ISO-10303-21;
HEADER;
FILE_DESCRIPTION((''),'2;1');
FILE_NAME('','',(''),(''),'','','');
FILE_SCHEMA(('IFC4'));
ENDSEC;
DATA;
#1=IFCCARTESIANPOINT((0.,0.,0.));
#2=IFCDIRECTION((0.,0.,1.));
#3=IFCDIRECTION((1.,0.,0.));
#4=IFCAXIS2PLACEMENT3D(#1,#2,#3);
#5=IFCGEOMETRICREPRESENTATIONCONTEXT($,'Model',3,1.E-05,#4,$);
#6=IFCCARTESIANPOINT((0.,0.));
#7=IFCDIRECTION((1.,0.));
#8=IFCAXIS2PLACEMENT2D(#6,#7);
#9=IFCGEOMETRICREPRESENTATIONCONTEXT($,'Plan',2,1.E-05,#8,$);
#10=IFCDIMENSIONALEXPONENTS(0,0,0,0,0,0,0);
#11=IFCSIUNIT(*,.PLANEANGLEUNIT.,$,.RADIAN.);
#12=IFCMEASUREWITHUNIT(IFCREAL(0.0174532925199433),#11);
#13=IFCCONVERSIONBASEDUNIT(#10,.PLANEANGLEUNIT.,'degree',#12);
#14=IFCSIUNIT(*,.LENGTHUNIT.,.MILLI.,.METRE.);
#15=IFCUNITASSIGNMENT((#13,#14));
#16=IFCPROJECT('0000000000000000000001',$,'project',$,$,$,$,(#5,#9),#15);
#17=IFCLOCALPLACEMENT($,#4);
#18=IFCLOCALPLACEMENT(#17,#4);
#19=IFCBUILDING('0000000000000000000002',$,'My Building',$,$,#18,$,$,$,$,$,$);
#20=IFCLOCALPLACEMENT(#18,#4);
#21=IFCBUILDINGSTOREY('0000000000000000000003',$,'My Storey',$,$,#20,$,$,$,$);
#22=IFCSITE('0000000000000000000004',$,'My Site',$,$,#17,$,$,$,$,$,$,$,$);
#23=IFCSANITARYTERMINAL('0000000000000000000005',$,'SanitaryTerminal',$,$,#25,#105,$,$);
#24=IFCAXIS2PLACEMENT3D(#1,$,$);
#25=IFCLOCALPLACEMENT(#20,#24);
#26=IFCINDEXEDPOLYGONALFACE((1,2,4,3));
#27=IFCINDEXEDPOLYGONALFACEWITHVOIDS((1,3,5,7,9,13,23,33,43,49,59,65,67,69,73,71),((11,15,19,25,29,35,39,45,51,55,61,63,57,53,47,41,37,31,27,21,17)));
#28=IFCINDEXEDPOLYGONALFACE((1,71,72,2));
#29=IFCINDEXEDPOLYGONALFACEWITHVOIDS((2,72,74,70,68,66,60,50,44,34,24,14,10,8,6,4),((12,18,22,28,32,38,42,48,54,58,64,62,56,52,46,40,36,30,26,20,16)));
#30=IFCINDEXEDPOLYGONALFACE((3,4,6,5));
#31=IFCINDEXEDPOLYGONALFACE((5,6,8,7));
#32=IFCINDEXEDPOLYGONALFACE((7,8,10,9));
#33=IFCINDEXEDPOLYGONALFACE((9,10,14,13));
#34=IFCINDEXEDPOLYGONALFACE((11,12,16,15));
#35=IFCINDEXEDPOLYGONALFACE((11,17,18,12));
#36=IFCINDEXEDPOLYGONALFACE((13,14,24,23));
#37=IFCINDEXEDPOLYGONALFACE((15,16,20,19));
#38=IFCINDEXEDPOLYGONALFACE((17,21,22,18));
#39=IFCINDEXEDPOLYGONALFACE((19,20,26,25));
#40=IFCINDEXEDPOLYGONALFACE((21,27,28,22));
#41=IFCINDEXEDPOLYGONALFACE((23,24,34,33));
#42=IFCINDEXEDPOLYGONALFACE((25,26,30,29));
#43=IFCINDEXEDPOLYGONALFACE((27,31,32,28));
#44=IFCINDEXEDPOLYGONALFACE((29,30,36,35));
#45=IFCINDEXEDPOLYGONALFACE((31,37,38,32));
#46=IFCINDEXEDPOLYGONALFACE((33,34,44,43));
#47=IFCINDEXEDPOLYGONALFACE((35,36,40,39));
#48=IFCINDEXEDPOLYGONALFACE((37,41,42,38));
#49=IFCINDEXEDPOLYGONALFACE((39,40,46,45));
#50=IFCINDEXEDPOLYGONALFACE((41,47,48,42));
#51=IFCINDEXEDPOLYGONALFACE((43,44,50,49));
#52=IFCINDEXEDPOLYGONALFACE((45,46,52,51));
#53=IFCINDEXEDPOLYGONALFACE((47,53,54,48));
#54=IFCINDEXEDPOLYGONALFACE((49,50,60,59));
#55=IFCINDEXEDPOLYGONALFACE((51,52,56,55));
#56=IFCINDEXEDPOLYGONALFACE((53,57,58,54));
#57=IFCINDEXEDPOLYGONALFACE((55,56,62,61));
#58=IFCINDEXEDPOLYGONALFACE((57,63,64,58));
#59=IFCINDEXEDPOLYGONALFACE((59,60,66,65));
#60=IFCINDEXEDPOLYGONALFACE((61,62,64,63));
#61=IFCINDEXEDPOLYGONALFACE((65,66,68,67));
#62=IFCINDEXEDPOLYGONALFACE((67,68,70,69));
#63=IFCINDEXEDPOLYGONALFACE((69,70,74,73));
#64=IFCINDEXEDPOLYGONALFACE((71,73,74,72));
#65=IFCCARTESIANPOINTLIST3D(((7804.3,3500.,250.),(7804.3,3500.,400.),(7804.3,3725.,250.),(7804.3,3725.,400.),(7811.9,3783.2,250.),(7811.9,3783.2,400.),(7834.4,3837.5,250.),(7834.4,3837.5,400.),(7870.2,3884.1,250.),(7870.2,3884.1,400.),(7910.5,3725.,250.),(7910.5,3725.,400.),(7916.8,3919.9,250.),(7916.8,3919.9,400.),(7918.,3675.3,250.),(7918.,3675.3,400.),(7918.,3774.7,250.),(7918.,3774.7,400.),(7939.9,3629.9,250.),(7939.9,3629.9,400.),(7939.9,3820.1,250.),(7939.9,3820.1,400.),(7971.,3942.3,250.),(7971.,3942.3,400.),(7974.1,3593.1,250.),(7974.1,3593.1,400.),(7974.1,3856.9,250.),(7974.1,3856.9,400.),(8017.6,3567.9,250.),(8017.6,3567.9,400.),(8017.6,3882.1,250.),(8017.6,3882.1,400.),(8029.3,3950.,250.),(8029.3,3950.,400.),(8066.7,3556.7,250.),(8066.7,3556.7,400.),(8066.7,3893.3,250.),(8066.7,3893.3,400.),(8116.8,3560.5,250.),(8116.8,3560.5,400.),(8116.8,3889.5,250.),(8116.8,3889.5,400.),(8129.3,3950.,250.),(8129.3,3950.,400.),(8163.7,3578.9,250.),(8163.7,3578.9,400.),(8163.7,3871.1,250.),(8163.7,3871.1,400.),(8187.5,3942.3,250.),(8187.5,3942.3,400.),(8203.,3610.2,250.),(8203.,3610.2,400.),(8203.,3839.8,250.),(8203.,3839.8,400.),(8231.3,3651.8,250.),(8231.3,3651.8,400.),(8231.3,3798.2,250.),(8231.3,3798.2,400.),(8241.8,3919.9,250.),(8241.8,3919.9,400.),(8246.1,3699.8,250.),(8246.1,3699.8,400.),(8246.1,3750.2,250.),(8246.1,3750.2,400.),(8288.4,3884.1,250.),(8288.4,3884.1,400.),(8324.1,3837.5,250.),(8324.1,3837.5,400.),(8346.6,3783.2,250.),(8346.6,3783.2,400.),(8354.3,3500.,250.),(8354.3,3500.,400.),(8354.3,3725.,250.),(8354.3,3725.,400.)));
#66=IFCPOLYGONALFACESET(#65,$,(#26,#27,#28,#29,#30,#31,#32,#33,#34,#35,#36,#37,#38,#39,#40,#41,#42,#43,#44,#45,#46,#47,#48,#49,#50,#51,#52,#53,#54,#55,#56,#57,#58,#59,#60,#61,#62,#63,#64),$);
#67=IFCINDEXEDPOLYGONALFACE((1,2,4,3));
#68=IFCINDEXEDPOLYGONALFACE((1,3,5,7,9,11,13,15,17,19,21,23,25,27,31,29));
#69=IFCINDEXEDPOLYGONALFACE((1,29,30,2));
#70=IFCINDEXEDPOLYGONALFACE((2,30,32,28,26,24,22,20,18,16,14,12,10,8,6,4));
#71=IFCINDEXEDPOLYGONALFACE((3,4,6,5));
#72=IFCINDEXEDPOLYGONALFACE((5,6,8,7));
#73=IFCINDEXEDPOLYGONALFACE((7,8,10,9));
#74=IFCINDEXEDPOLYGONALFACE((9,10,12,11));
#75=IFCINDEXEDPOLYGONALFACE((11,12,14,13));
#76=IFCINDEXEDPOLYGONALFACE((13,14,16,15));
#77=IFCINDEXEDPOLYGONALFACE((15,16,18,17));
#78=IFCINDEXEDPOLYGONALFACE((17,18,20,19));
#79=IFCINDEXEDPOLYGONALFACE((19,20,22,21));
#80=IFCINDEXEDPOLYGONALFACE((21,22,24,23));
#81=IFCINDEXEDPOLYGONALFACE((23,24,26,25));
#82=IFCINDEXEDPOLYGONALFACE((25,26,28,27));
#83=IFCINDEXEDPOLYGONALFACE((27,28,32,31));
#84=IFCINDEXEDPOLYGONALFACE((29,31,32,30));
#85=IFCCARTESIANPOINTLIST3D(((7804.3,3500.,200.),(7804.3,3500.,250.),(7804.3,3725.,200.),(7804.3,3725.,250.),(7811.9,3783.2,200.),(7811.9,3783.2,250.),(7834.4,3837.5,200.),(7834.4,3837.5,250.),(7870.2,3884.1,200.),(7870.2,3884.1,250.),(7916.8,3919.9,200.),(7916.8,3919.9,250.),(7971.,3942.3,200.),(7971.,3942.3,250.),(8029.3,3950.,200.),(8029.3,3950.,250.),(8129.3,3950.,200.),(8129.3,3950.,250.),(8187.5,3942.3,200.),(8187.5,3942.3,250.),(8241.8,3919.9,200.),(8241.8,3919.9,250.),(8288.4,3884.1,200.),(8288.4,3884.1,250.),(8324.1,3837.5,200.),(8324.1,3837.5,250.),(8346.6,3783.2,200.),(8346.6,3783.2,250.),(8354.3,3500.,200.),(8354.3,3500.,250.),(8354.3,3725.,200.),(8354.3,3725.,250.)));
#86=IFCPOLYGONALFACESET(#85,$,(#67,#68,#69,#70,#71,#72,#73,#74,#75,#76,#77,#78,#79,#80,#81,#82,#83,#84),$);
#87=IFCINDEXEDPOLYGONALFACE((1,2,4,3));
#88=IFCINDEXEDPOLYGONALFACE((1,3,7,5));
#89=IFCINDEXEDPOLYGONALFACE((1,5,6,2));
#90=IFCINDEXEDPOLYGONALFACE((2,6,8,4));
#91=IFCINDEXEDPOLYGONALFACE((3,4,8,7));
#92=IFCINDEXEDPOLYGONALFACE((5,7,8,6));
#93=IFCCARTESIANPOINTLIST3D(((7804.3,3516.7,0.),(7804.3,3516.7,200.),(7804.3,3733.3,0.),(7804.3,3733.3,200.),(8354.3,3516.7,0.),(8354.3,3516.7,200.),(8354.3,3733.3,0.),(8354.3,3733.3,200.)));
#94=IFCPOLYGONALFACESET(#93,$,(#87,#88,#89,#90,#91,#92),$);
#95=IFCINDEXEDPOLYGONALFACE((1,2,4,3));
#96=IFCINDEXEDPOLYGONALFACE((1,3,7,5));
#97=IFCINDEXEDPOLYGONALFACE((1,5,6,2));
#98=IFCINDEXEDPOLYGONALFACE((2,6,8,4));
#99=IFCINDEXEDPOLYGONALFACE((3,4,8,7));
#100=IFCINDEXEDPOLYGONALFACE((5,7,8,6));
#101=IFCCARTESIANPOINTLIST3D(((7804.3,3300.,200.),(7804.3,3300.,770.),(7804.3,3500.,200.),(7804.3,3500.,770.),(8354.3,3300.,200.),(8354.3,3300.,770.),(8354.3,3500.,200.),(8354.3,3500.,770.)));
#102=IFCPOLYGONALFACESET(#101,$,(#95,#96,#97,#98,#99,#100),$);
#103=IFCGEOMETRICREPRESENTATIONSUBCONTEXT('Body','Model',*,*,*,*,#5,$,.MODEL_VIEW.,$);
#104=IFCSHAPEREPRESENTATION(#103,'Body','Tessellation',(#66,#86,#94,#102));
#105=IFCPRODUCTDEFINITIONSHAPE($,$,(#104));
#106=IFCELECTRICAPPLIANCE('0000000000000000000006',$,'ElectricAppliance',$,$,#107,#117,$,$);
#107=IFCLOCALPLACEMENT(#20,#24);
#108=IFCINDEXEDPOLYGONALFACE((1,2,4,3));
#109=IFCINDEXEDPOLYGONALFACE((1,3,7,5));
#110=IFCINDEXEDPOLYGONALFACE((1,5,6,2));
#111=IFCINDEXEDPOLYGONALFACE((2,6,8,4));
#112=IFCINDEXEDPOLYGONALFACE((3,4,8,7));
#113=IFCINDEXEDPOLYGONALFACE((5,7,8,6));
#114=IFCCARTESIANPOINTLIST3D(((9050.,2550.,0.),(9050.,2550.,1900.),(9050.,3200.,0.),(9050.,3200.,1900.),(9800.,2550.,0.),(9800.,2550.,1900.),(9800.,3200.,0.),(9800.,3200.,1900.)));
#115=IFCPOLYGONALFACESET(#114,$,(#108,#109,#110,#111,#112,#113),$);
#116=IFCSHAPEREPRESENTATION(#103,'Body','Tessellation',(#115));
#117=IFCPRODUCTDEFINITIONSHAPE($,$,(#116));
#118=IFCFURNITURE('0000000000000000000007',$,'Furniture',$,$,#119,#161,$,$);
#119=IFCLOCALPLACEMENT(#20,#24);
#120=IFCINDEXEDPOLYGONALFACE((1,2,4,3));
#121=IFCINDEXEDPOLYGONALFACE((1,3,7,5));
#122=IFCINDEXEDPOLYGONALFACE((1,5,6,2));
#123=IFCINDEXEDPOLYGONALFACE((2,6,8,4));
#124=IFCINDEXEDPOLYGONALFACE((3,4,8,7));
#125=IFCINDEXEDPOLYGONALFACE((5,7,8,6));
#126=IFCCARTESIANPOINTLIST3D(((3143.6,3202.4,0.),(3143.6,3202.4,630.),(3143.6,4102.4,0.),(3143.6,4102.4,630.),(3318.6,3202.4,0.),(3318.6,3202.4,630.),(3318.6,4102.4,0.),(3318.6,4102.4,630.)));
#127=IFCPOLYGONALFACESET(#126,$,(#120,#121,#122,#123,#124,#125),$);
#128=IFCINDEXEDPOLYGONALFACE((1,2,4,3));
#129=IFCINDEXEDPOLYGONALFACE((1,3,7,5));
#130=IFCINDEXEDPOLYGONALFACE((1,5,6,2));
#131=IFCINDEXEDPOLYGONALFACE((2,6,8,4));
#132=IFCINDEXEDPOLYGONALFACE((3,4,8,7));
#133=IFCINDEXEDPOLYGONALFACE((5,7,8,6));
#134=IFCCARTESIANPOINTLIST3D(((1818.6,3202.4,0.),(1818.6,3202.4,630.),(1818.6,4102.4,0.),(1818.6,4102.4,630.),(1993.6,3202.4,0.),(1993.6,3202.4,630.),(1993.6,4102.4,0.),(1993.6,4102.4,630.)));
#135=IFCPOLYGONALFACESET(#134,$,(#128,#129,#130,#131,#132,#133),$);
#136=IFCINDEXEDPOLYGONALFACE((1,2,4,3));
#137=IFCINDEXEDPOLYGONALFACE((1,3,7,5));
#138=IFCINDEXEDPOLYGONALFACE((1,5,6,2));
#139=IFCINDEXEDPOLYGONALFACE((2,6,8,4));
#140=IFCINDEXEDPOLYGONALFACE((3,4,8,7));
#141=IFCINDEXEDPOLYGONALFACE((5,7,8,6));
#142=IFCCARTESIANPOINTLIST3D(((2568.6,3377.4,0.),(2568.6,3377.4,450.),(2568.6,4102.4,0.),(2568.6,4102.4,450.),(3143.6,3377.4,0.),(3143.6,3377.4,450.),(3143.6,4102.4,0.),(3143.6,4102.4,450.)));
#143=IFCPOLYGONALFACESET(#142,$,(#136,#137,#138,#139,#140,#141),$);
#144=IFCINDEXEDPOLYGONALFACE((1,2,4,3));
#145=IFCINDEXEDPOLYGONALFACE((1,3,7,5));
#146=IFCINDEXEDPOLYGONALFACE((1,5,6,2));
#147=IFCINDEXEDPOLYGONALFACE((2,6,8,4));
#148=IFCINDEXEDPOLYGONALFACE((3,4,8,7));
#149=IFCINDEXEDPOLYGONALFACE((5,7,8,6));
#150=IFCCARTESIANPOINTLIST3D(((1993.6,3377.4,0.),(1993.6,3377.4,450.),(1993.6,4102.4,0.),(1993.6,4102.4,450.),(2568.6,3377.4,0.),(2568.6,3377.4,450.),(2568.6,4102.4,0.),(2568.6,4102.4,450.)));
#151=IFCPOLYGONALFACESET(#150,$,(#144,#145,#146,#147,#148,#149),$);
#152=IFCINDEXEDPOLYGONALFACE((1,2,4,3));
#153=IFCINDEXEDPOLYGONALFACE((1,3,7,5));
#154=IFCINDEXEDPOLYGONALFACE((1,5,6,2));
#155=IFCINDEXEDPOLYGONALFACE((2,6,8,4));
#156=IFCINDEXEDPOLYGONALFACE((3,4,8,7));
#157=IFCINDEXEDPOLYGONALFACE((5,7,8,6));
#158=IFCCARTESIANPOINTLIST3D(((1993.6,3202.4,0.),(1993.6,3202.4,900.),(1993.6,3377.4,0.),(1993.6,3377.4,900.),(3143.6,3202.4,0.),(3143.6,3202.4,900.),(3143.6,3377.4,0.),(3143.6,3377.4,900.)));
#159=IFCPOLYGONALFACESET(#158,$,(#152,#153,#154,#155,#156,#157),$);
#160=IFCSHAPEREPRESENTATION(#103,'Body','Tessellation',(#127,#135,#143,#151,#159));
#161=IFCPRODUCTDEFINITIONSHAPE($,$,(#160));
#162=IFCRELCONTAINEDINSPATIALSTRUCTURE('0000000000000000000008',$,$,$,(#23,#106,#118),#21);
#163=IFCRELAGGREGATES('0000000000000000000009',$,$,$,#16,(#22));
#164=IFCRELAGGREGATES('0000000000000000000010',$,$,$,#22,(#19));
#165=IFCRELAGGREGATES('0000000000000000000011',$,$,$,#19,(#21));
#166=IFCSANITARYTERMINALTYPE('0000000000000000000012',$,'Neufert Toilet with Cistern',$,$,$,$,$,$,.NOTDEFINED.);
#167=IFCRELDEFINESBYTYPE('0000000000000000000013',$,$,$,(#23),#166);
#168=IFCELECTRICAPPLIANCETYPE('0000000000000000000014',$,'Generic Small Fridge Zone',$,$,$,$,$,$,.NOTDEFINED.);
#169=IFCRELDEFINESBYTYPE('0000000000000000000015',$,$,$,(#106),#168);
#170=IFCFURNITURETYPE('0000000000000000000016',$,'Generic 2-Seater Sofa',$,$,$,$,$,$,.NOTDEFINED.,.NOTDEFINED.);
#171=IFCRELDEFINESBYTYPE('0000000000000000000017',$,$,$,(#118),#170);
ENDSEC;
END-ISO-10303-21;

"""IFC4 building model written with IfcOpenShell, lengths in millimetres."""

from ifc_helpers import new_model, entity, si_unit, converted_unit, frame, frame_2d, origin_with_axes, origin_2d_with_axis, place, context, subcontext, project, spatial, line, arc, indexed_curve, circle_curve, outline, extrude, shape, source, transform, mapped, type_object, type_shapes, element, save


model = new_model("IFC4")

# Units and contexts
model_context = context("Model", 3, precision=1e-05, world=origin_with_axes())
plan_context = context("Plan", 2, precision=1e-05, world=origin_2d_with_axis())
body_context_1 = subcontext(model_context, "Body", "Model", "MODEL_VIEW")
body_context_2 = subcontext(plan_context, "Body", "Plan", "PLAN_VIEW")
ifc_project = project(units=[converted_unit("PLANEANGLEUNIT", "degree", entity("IfcReal", 0.0174532925199433), si_unit("PLANEANGLEUNIT", "RADIAN"), dimensions=[0, 0, 0, 0, 0, 0, 0]), si_unit("LENGTHUNIT", "METRE", prefix="MILLI")], contexts=[model_context, plan_context])

# Site, building, storey
site_placement = place(None, origin_with_axes())
site = spatial("IfcSite", under=ifc_project, at=site_placement, Name="My Site")
building_placement = place(site_placement, origin_with_axes())
building = spatial("IfcBuilding", under=site, at=building_placement, Name="My Building")
storey_placement = place(building_placement, origin_with_axes())
storey = spatial("IfcBuildingStorey", under=building, at=storey_placement, Name="My Storey")

# Sanitary terminal
sanitary_terminal_type_1 = type_object("IfcSanitaryTerminalType", Name="Neufert Toilet with Cistern", PredefinedType="NOTDEFINED")
shared_shape_1 = source(origin_with_axes(), body_context_1, "Body", "SweptSolid", [
    extrude(outline(indexed_curve([(-275.0, -200.0), (275.0, -200.0), (275.0, -425.0), (209.1, -584.1), (50.0, -650.0), (-50.0, -650.0), (-209.1, -584.1), (-275.0, -425.0)], segments=[line(1, 2), line(2, 3), arc(3, 4, 5), line(5, 6), arc(6, 7, 8), line(8, 1)]), holes=[circle_curve(frame_2d((0.0, -425.0)), 168.8)]), frame((0.0, 0.0, 250.0), z_axis=(0.0, 0.0, 1.0), x_axis=(1.0, 0.0, 0.0)), (0.0, 0.0, 1.0), 150.0),
    extrude(outline(indexed_curve([(-275.0, -200.0), (275.0, -200.0), (275.0, -425.0), (209.1, -584.1), (50.0, -650.0), (-50.0, -650.0), (-209.1, -584.1), (-275.0, -425.0)], segments=[line(1, 2), line(2, 3), arc(3, 4, 5), line(5, 6), arc(6, 7, 8), line(8, 1)])), frame((0.0, 0.0, 200.0), z_axis=(0.0, 0.0, 1.0), x_axis=(1.0, 0.0, 0.0)), (0.0, 0.0, 1.0), 50.0),
    extrude(outline(indexed_curve([(-275.0, -216.7), (275.0, -216.7), (275.0, -433.3), (-275.0, -433.3)], segments=[line(1, 2, 3, 4, 1)])), origin_with_axes(), (0.0, 0.0, 1.0), 200.0),
    extrude(outline(indexed_curve([(-275.0, 0.0), (275.0, 0.0), (275.0, -200.0), (-275.0, -200.0)], segments=[line(1, 2, 3, 4, 1)])), frame((0.0, 0.0, 200.0), z_axis=(0.0, 0.0, 1.0), x_axis=(1.0, 0.0, 0.0)), (0.0, 0.0, 1.0), 570.0),
])
shared_shape_2 = source(origin_with_axes(), body_context_2, "Body", "Curve2D", [
    entity("IfcIndexedPolyCurve", entity("IfcCartesianPointList2D", [[-275.0, 0.0], [275.0, 0.0], [275.0, -200.0], [-275.0, -200.0]]), [entity("IfcLineIndex", [1, 2, 3, 4, 1])]),
    entity("IfcIndexedPolyCurve", entity("IfcCartesianPointList2D", [[165.0, -200.0], [192.5, -335.0]])),
    entity("IfcTrimmedCurve", entity("IfcEllipse", entity("IfcAxis2Placement2D", entity("IfcCartesianPoint", [0.0, -335.0]), entity("IfcDirection", [1.0, 0.0])), 192.5, 315.0), [entity("IfcCartesianPoint", [-192.5, -335.0])], [entity("IfcCartesianPoint", [192.5, -335.0])], True, "CARTESIAN"),
    entity("IfcIndexedPolyCurve", entity("IfcCartesianPointList2D", [[-165.0, -200.0], [-192.5, -335.0]])),
    entity("IfcEllipse", entity("IfcAxis2Placement2D", entity("IfcCartesianPoint", [0.0, -452.0]), entity("IfcDirection", [1.0, 0.0])), 131.2, 157.5),
    entity("IfcIndexedPolyCurve", entity("IfcCartesianPointList2D", [[-34.4, -452.0], [-34.4, -429.5], [34.4, -429.5], [34.4, -452.0]])),
    entity("IfcTrimmedCurve", entity("IfcEllipse", entity("IfcAxis2Placement2D", entity("IfcCartesianPoint", [0.0, -452.0]), entity("IfcDirection", [1.0, 0.0])), 34.4, 22.5), [entity("IfcCartesianPoint", [-34.4, -452.0])], [entity("IfcCartesianPoint", [34.4, -452.0])], True, "CARTESIAN"),
])
type_shapes(sanitary_terminal_type_1, [shared_shape_1, shared_shape_2])
sanitary_terminal_1_placement = place(storey_placement, frame((8079.3, 3300.0, 0.0), z_axis=(0.0, 0.0, 1.0), x_axis=(-1.0, 0.0, 0.0)))
element("IfcSanitaryTerminal", 1, at=sanitary_terminal_1_placement, inside=storey, type_object=sanitary_terminal_type_1, Name="SanitaryTerminal", shapes=[
    shape(body_context_1, "Body", "MappedRepresentation", [mapped(shared_shape_1, transform((0.0, 0.0, 0.0), x_axis=(1.0, 0.0, 0.0), y_axis=(0.0, 1.0, 0.0), z_axis=(0.0, 0.0, 1.0), scale=1.0))]),
    shape(body_context_2, "Body", "MappedRepresentation", [mapped(shared_shape_2, transform((0.0, 0.0, 0.0), x_axis=(1.0, 0.0, 0.0), y_axis=(0.0, 1.0, 0.0), z_axis=(0.0, 0.0, 1.0), scale=1.0))]),
])

# Electric appliance
electric_appliance_type_1 = type_object("IfcElectricApplianceType", Name="Generic Small Fridge Zone", PredefinedType="NOTDEFINED")
shared_shape_3 = source(origin_with_axes(), body_context_1, "Body", "SweptSolid", [
    extrude(outline(indexed_curve([(0.0, 0.0), (750.0, 0.0), (750.0, 650.0), (0.0, 650.0)], segments=[line(1, 2, 3, 4, 1)])), origin_with_axes(), (0.0, 0.0, 1.0), 1900.0),
])
shared_shape_4 = source(origin_with_axes(), body_context_2, "Body", "Curve2D", [
    entity("IfcIndexedPolyCurve", entity("IfcCartesianPointList2D", [[0.0, 0.0], [750.0, 0.0], [750.0, 650.0], [0.0, 650.0]]), [entity("IfcLineIndex", [1, 2, 3, 4, 1])]),
])
type_shapes(electric_appliance_type_1, [shared_shape_3, shared_shape_4])
electric_appliance_1_placement = place(storey_placement, frame((9050.0, 2550.0, 0.0), z_axis=(0.0, 0.0, 1.0), x_axis=(1.0, 0.0, 0.0)))
element("IfcElectricAppliance", 2, at=electric_appliance_1_placement, inside=storey, type_object=electric_appliance_type_1, Name="ElectricAppliance", shapes=[
    shape(body_context_1, "Body", "MappedRepresentation", [mapped(shared_shape_3, transform((0.0, 0.0, 0.0), x_axis=(1.0, 0.0, 0.0), y_axis=(0.0, 1.0, 0.0), z_axis=(0.0, 0.0, 1.0), scale=1.0))]),
    shape(body_context_2, "Body", "MappedRepresentation", [mapped(shared_shape_4, transform((0.0, 0.0, 0.0), x_axis=(1.0, 0.0, 0.0), y_axis=(0.0, 1.0, 0.0), z_axis=(0.0, 0.0, 1.0), scale=1.0))]),
])

# Furniture
furniture_type_1 = type_object("IfcFurnitureType", Name="Generic 2-Seater Sofa", AssemblyPlace="NOTDEFINED", PredefinedType="NOTDEFINED")
shared_shape_5 = source(origin_with_axes(), body_context_1, "Body", "SweptSolid", [
    extrude(outline(indexed_curve([(0.0, 0.0), (175.0, 0.0), (175.0, 900.0), (0.0, 900.0)], segments=[line(1, 2, 3, 4, 1)])), frame((-750.0, -900.0, 0.0), z_axis=(0.0, 0.0, 1.0), x_axis=(1.0, 0.0, 0.0)), (0.0, 0.0, 1.0), 630.0),
    extrude(outline(indexed_curve([(0.0, 0.0), (175.0, 0.0), (175.0, 900.0), (0.0, 900.0)], segments=[line(1, 2, 3, 4, 1)])), frame((575.0, -900.0, 0.0), z_axis=(0.0, 0.0, 1.0), x_axis=(1.0, 0.0, 0.0)), (0.0, 0.0, 1.0), 630.0),
    extrude(outline(indexed_curve([(175.0, 0.0), (750.0, 0.0), (750.0, 725.0), (175.0, 725.0)], segments=[line(1, 2, 3, 4, 1)])), frame((-750.0, -900.0, 0.0), z_axis=(0.0, 0.0, 1.0), x_axis=(1.0, 0.0, 0.0)), (0.0, 0.0, 1.0), 450.0),
    extrude(outline(indexed_curve([(750.0, 0.0), (1325.0, 0.0), (1325.0, 725.0), (750.0, 725.0)], segments=[line(1, 2, 3, 4, 1)])), frame((-750.0, -900.0, 0.0), z_axis=(0.0, 0.0, 1.0), x_axis=(1.0, 0.0, 0.0)), (0.0, 0.0, 1.0), 450.0),
    extrude(outline(indexed_curve([(175.0, 725.0), (1325.0, 725.0), (1325.0, 900.0), (175.0, 900.0)], segments=[line(1, 2, 3, 4, 1)])), frame((-750.0, -900.0, 0.0), z_axis=(0.0, 0.0, 1.0), x_axis=(1.0, 0.0, 0.0)), (0.0, 0.0, 1.0), 900.0),
])
shared_shape_6 = source(origin_with_axes(), body_context_2, "Body", "Curve2D", [
    entity("IfcIndexedPolyCurve", entity("IfcCartesianPointList2D", [[-750.0, -900.0], [-575.0, -900.0], [-575.0, 0.0], [-750.0, 0.0]]), [entity("IfcLineIndex", [1, 2, 3, 4, 1])]),
    entity("IfcIndexedPolyCurve", entity("IfcCartesianPointList2D", [[575.0, -900.0], [750.0, -900.0], [750.0, 0.0], [575.0, 0.0]]), [entity("IfcLineIndex", [1, 2, 3, 4, 1])]),
    entity("IfcIndexedPolyCurve", entity("IfcCartesianPointList2D", [[-575.0, -900.0], [0.0, -900.0], [0.0, -175.0], [-575.0, -175.0]]), [entity("IfcLineIndex", [1, 2, 3, 4, 1])]),
    entity("IfcIndexedPolyCurve", entity("IfcCartesianPointList2D", [[0.0, -900.0], [575.0, -900.0], [575.0, -175.0], [0.0, -175.0]]), [entity("IfcLineIndex", [1, 2, 3, 4, 1])]),
    entity("IfcIndexedPolyCurve", entity("IfcCartesianPointList2D", [[-575.0, -175.0], [575.0, -175.0], [575.0, 0.0], [-575.0, 0.0]]), [entity("IfcLineIndex", [1, 2, 3, 4, 1])]),
])
type_shapes(furniture_type_1, [shared_shape_5, shared_shape_6])
furniture_1_placement = place(storey_placement, frame((2568.6, 3202.4, 0.0), z_axis=(0.0, 0.0, 1.0), x_axis=(-1.0, 0.0, 0.0)))
element("IfcFurniture", 3, at=furniture_1_placement, inside=storey, type_object=furniture_type_1, Name="Furniture", shapes=[
    shape(body_context_1, "Body", "MappedRepresentation", [mapped(shared_shape_5, transform((0.0, 0.0, 0.0), x_axis=(1.0, 0.0, 0.0), y_axis=(0.0, 1.0, 0.0), z_axis=(0.0, 0.0, 1.0), scale=1.0))]),
    shape(body_context_2, "Body", "MappedRepresentation", [mapped(shared_shape_6, transform((0.0, 0.0, 0.0), x_axis=(1.0, 0.0, 0.0), y_axis=(0.0, 1.0, 0.0), z_axis=(0.0, 0.0, 1.0), scale=1.0))]),
])

save(model, "model.ifc")
